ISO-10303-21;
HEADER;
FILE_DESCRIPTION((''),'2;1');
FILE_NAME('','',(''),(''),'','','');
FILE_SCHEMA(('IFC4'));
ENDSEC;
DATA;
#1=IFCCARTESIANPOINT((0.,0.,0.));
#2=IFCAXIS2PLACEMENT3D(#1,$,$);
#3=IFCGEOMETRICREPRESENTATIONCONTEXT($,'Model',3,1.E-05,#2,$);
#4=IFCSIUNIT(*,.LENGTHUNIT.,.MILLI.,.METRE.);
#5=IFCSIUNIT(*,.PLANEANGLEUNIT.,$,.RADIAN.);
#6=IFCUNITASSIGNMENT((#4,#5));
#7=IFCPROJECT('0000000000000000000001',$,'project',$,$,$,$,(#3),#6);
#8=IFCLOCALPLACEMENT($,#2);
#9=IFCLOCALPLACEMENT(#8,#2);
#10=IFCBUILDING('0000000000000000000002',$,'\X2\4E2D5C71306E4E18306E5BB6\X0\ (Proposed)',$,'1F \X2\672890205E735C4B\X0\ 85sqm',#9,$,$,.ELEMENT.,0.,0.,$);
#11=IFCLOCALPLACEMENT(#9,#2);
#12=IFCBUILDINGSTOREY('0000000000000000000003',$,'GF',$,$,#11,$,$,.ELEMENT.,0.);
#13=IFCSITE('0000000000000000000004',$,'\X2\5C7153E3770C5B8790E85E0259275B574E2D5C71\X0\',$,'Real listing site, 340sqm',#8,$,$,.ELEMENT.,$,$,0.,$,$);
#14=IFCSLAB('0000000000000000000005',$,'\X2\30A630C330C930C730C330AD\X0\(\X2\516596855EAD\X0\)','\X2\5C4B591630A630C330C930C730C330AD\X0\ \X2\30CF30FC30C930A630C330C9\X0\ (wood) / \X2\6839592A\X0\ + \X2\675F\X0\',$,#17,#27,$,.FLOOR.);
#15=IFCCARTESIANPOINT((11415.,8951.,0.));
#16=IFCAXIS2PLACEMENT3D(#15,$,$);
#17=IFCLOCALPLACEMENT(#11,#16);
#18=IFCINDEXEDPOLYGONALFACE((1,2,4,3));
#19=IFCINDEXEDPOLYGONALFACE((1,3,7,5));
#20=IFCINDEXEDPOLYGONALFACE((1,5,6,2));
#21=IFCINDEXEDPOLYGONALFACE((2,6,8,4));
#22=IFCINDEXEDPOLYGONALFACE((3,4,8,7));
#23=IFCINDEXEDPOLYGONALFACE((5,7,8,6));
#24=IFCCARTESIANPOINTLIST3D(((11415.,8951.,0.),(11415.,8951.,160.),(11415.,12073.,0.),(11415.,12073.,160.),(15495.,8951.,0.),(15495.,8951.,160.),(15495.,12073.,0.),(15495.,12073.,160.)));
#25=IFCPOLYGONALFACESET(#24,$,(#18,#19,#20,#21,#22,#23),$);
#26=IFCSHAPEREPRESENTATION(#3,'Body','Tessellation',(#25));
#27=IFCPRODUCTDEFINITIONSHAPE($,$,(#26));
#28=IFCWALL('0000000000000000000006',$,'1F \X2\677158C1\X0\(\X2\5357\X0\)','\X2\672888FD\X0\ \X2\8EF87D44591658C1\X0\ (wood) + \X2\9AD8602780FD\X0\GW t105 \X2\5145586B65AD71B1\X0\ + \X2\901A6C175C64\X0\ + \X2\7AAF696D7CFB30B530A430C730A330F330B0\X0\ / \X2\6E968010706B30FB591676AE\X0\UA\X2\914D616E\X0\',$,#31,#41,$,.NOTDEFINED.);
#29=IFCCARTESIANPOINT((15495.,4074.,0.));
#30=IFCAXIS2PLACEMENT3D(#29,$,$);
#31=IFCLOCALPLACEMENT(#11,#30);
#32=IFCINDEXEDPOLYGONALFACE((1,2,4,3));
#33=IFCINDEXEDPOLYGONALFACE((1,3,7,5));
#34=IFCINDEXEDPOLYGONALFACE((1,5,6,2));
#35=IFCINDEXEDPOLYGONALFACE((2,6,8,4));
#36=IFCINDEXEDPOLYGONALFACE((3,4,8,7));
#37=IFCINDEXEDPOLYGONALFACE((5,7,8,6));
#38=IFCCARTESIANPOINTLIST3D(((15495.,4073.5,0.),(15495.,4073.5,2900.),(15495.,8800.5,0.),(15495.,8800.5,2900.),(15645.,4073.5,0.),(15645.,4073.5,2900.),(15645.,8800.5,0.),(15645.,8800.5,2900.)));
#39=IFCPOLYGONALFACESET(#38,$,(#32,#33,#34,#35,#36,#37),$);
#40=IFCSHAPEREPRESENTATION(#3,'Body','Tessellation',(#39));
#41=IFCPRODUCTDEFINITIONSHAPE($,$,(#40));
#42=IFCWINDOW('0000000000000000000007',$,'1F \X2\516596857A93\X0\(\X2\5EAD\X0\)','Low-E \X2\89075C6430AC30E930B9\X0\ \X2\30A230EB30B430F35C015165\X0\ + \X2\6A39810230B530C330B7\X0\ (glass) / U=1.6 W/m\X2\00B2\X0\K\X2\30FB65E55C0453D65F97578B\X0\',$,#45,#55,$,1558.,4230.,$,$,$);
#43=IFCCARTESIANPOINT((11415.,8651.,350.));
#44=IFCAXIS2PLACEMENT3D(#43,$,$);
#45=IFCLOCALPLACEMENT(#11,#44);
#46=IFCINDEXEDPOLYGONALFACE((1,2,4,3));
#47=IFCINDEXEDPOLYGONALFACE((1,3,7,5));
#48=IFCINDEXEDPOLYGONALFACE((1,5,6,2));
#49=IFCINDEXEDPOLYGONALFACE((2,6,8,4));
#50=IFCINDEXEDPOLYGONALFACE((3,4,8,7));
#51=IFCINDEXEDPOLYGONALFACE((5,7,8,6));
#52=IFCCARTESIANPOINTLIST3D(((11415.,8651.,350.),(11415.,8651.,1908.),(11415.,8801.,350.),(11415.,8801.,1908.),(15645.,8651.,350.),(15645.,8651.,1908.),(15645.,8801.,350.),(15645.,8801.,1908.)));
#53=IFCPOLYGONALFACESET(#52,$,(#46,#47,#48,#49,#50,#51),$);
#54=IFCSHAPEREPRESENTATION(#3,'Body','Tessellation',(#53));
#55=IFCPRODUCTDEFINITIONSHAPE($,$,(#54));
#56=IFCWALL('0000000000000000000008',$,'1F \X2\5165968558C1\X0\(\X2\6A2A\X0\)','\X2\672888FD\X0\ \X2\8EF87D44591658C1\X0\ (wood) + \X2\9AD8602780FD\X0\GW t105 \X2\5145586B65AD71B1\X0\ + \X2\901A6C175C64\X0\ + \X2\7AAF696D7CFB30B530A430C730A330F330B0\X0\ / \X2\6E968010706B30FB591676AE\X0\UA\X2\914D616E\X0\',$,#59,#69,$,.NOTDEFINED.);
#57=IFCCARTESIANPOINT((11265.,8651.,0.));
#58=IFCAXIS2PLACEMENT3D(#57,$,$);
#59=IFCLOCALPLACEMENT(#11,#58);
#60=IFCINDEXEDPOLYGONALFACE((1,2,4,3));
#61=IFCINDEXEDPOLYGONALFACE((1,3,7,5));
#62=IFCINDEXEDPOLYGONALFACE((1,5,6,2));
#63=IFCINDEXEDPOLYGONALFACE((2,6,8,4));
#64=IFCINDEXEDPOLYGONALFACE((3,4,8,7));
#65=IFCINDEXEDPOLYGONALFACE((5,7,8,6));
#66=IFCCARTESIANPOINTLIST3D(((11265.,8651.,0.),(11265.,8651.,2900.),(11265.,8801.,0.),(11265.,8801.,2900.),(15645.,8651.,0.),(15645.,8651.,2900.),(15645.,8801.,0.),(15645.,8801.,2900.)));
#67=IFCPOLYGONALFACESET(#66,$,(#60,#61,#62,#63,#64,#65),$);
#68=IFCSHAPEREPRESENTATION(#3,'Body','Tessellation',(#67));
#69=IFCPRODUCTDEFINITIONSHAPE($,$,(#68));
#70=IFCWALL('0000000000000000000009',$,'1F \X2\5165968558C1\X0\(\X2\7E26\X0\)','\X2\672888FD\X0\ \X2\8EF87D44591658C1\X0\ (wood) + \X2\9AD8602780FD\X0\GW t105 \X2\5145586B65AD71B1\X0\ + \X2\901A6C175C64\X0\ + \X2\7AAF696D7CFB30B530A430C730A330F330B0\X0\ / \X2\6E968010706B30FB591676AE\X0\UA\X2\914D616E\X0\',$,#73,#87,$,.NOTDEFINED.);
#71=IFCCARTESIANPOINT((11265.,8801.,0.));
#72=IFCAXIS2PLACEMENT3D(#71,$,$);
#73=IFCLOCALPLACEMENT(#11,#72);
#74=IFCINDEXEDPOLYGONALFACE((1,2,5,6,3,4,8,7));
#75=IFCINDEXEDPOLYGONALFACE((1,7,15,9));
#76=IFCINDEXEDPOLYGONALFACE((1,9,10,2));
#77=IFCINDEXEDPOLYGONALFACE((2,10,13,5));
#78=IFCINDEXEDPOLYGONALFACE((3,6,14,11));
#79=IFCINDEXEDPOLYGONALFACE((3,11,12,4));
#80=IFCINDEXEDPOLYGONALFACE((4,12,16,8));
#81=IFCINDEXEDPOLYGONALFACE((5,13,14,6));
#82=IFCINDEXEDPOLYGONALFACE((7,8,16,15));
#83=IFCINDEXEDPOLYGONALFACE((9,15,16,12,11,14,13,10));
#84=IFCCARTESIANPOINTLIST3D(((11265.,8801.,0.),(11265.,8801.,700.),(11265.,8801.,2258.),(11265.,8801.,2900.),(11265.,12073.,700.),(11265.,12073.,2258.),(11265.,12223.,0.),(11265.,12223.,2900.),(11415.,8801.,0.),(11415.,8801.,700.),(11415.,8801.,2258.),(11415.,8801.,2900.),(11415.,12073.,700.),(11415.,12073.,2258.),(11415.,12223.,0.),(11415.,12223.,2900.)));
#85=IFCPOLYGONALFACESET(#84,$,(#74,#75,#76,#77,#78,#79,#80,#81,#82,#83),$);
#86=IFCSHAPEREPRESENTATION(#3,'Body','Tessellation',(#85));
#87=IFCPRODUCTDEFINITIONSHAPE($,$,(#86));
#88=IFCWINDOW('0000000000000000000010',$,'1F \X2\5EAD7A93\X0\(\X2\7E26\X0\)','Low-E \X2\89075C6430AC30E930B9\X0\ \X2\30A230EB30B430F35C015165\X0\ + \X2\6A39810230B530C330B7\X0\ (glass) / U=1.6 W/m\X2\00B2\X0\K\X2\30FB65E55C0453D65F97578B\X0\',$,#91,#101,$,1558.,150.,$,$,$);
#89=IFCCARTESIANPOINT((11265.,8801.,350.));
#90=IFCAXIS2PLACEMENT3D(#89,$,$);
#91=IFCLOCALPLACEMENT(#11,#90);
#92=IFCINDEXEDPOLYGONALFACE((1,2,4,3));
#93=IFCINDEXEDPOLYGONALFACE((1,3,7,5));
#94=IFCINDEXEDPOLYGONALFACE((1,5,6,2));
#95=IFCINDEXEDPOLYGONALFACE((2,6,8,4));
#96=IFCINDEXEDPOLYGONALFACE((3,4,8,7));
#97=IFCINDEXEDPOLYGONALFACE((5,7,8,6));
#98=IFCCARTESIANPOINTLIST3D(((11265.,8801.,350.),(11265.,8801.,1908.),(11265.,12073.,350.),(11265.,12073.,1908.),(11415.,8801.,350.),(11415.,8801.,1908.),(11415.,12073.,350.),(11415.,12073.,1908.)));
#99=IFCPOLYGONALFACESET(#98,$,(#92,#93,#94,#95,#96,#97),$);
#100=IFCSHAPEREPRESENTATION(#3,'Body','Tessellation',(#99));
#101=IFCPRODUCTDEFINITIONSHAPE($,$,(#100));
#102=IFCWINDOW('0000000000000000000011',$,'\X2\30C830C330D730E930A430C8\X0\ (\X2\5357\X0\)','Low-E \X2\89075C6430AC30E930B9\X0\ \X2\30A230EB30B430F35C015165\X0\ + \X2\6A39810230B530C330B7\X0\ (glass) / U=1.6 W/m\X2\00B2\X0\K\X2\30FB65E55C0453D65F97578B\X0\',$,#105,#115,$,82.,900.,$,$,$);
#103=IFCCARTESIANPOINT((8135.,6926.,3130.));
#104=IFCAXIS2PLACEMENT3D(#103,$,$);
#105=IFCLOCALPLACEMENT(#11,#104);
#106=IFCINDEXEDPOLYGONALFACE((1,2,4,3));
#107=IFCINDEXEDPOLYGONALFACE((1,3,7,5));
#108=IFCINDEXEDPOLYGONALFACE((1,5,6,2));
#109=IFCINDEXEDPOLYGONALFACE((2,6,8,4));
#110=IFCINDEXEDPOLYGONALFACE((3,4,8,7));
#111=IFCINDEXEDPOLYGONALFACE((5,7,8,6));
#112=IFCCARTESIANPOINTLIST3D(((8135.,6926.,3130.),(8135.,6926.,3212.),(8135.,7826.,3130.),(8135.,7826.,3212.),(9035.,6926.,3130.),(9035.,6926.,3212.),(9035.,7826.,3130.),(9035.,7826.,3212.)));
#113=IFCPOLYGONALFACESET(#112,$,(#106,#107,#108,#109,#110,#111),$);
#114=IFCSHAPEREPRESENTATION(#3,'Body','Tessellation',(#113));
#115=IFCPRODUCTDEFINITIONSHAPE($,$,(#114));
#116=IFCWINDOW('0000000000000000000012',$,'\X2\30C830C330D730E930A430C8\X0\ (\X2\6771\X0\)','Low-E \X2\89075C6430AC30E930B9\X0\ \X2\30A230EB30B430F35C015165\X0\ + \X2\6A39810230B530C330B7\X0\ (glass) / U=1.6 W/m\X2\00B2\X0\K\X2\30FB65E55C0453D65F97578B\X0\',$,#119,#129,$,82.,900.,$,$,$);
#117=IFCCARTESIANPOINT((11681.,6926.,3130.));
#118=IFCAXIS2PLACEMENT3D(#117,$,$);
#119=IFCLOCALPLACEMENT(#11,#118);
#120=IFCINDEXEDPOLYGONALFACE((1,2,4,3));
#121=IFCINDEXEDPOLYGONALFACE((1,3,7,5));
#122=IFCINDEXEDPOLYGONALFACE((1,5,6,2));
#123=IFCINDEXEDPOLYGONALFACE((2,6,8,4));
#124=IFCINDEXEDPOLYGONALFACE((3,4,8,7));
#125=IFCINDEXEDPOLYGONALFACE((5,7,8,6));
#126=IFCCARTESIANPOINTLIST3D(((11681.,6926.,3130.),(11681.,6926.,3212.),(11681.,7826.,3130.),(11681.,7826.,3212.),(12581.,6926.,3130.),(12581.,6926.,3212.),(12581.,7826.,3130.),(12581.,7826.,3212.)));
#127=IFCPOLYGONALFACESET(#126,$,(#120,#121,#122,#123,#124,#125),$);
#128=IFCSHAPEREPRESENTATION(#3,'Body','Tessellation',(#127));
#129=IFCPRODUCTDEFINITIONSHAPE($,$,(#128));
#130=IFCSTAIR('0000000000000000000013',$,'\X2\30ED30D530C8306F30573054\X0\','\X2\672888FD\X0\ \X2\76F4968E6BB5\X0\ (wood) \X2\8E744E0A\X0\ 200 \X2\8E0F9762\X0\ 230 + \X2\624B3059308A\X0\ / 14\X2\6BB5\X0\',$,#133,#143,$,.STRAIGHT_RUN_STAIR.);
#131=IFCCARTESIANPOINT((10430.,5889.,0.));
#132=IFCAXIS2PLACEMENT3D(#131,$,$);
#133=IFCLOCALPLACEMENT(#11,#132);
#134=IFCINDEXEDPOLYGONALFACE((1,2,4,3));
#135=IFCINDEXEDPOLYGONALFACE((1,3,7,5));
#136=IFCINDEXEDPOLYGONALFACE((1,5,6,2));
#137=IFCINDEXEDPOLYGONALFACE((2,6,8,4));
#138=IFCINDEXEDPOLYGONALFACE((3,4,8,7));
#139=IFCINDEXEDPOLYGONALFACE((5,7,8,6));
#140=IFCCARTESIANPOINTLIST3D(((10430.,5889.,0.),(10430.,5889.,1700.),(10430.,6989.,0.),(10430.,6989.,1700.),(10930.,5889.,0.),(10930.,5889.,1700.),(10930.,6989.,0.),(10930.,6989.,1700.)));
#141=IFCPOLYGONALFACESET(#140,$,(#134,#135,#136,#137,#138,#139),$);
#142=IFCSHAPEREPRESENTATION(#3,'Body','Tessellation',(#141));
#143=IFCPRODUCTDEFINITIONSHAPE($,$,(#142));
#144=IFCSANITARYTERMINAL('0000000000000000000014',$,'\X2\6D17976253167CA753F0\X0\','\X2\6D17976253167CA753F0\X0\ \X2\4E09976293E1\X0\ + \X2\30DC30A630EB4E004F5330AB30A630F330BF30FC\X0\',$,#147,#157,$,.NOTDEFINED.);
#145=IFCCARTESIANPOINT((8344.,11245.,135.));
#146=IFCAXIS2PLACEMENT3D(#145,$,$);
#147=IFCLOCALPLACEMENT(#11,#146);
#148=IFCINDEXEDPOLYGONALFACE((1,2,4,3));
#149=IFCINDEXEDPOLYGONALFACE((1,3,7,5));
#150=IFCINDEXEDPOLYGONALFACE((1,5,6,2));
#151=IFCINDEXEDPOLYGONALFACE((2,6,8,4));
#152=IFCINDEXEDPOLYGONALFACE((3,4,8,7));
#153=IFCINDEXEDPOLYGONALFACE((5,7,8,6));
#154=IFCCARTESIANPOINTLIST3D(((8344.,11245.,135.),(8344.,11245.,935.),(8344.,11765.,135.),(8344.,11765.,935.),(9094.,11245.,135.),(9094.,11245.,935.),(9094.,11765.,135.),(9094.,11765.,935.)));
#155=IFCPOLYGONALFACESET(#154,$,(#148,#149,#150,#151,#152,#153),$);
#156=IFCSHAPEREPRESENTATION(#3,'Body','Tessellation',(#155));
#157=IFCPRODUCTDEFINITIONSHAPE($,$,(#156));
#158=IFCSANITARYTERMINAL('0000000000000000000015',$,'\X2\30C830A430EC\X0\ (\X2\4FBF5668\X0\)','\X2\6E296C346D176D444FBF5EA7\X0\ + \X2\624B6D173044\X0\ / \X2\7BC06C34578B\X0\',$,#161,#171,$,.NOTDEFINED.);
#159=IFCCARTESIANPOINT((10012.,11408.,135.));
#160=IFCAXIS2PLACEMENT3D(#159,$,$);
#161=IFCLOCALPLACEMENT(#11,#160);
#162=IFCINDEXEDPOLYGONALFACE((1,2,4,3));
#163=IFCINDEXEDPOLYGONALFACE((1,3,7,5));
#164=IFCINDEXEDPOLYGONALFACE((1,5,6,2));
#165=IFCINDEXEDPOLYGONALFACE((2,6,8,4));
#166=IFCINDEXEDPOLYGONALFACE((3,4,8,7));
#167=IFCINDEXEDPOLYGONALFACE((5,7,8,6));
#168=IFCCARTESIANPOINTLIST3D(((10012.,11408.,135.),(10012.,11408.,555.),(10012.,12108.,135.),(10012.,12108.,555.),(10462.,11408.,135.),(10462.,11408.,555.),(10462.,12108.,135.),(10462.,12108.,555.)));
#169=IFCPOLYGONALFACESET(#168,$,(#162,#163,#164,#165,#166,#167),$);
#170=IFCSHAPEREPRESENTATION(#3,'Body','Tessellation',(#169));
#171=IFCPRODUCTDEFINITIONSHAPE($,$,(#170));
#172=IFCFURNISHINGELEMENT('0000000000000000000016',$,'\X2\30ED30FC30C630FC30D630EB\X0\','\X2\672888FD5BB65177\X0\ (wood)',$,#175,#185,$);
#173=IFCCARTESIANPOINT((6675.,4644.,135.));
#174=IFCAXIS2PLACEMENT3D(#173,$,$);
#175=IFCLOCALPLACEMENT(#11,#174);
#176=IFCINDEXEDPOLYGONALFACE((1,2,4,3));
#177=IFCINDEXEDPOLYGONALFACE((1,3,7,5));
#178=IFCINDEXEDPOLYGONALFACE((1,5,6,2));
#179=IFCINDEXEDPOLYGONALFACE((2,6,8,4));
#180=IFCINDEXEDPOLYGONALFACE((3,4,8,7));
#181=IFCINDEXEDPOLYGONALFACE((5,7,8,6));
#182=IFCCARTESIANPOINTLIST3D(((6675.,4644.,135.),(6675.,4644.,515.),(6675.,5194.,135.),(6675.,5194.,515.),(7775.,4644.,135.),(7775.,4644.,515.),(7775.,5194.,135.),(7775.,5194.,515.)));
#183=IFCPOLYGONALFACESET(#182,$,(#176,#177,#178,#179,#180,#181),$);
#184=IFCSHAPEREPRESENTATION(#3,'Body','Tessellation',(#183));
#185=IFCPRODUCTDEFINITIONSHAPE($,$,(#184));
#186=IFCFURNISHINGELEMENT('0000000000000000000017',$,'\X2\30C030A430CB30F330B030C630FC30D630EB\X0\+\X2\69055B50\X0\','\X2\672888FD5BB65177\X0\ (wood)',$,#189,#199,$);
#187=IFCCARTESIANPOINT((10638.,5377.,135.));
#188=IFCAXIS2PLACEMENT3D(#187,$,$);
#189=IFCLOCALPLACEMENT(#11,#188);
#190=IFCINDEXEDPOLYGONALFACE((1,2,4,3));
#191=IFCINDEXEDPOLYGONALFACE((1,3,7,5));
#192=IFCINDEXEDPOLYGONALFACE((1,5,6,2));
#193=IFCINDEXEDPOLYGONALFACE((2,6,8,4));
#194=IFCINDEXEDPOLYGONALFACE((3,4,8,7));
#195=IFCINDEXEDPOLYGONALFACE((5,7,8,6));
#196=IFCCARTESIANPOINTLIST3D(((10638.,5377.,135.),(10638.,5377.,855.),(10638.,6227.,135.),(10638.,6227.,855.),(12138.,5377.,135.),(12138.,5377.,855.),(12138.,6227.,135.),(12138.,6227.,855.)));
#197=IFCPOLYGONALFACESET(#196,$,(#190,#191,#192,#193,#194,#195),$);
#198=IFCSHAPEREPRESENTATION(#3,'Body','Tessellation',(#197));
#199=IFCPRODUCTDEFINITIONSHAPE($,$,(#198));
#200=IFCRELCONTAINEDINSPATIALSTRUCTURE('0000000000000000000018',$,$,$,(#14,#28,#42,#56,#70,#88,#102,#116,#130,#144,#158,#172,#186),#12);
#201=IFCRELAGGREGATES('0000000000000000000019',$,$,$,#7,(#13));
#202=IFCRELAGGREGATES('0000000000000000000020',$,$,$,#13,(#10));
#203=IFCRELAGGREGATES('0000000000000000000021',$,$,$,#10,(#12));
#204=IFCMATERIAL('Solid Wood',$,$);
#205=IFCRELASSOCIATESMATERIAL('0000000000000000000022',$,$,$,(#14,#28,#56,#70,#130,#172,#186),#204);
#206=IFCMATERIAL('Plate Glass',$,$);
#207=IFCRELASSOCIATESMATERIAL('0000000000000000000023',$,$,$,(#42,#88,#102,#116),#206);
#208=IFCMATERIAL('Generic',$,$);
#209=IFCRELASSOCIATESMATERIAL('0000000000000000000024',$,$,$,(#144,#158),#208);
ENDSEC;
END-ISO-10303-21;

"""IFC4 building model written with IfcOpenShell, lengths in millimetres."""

from ifc_helpers import new_model, si_unit, frame, frame_2d, origin, place, context, project, spatial, rectangle, extrude, material, element, fill, save


model = new_model("IFC4")

# Units and contexts
model_context = context("Model", 3, precision=1e-05, world=origin())
ifc_project = project(units=[si_unit("LENGTHUNIT", "METRE", prefix="MILLI"), si_unit("PLANEANGLEUNIT", "RADIAN")], contexts=[model_context])

# Site, building, storey
site_placement = place(None, origin())
site = spatial("IfcSite", under=ifc_project, at=site_placement, Name="山口県宇部市大字中山", ObjectType="Real listing site, 340sqm", CompositionType="ELEMENT", RefElevation=0.0)
building_placement = place(site_placement, origin())
building = spatial("IfcBuilding", under=site, at=building_placement, Name="中山の丘の家 (Proposed)", ObjectType="1F 木造平屋 85sqm", CompositionType="ELEMENT", ElevationOfRefHeight=0.0, ElevationOfTerrain=0.0)
storey_placement = place(building_placement, origin())
storey = spatial("IfcBuildingStorey", under=building, at=storey_placement, Name="GF", CompositionType="ELEMENT", Elevation=0.0)

# Slab
ifc_material_1 = material(Name="Solid Wood")
slab_placement = place(storey_placement, frame((11415.0, 8951.0, 0.0)))
element("IfcSlab", 1, at=slab_placement, inside=storey, material=ifc_material_1, Name="ウッドデッキ(入隅庭)", Description="屋外ウッドデッキ ハードウッド (wood) / 根太 + 束", PredefinedType="FLOOR", context=model_context, shape_type="SweptSolid", body=[
    extrude(rectangle(XDim=4080.0, YDim=3122.0, at=frame_2d((2040.0, 1561.0))), frame((11415.0, 8951.0, 0.0)), (0.0, 0.0, 1.0), 160.0),
])

# Wall, opening, window
wall_1_placement = place(storey_placement, frame((15495.0, 4074.0, 0.0)))
wall_1 = element("IfcWall", 2, at=wall_1_placement, inside=storey, material=ifc_material_1, Name="1F 東壁(南)", Description="木製 軸組外壁 (wood) + 高性能GW t105 充填断熱 + 通気層 + 窯業系サイディング / 準耐火・外皮UA配慮", PredefinedType="NOTDEFINED", context=model_context, shape_type="SweptSolid", body=[
    extrude(rectangle(XDim=150.0, YDim=4727.0, at=frame_2d((75.0, 2363.0))), frame((15495.0, 4074.0, 0.0)), (0.0, 0.0, 1.0), 2900.0),
])
opening_1_placement = place(storey_placement, frame((11415.0, 8651.0, 350.0)))
opening_1 = element("IfcOpeningElement", 3, at=opening_1_placement, cuts=wall_1, PredefinedType="NOTDEFINED", context=model_context, shape_type="SweptSolid", body=[
    extrude(rectangle(XDim=4230.0, YDim=150.0, at=frame_2d((2115.0, 75.0))), frame((11415.0, 8651.0, 350.0)), (0.0, 0.0, 1.0), 1558.0),
])
ifc_material_2 = material(Name="Plate Glass")
window_1_placement = place(storey_placement, frame((11415.0, 8651.0, 350.0)))
window_1 = element("IfcWindow", 4, at=window_1_placement, inside=storey, material=ifc_material_2, Name="1F 入隅窓(庭)", Description="Low-E 複層ガラス アルゴン封入 + 樹脂サッシ (glass) / U=1.6 W/m²K・日射取得型", OverallHeight=1558.0, OverallWidth=4230.0, context=model_context, shape_type="SweptSolid", body=[
    extrude(rectangle(XDim=4230.0, YDim=150.0, at=frame_2d((2115.0, 75.0))), frame((11415.0, 8651.0, 350.0)), (0.0, 0.0, 1.0), 1558.0),
])
fill(opening_1, window_1)

# Wall
wall_2_placement = place(storey_placement, frame((11265.0, 8651.0, 0.0)))
element("IfcWall", 5, at=wall_2_placement, inside=storey, material=ifc_material_1, Name="1F 入隅壁(横)", Description="木製 軸組外壁 (wood) + 高性能GW t105 充填断熱 + 通気層 + 窯業系サイディング / 準耐火・外皮UA配慮", PredefinedType="NOTDEFINED", context=model_context, shape_type="SweptSolid", body=[
    extrude(rectangle(XDim=4380.0, YDim=150.0, at=frame_2d((2190.0, 75.0))), frame((11265.0, 8651.0, 0.0)), (0.0, 0.0, 1.0), 2900.0),
])

# Wall, opening, window
wall_3_placement = place(storey_placement, frame((11265.0, 8801.0, 0.0)))
wall_3 = element("IfcWall", 6, at=wall_3_placement, inside=storey, material=ifc_material_1, Name="1F 入隅壁(縦)", Description="木製 軸組外壁 (wood) + 高性能GW t105 充填断熱 + 通気層 + 窯業系サイディング / 準耐火・外皮UA配慮", PredefinedType="NOTDEFINED", context=model_context, shape_type="SweptSolid", body=[
    extrude(rectangle(XDim=150.0, YDim=3422.0, at=frame_2d((75.0, 1711.0))), frame((11265.0, 8801.0, 0.0)), (0.0, 0.0, 1.0), 2900.0),
])
opening_2_placement = place(storey_placement, frame((11265.0, 8801.0, 350.0)))
opening_2 = element("IfcOpeningElement", 7, at=opening_2_placement, cuts=wall_3, PredefinedType="NOTDEFINED", context=model_context, shape_type="SweptSolid", body=[
    extrude(rectangle(XDim=150.0, YDim=3272.0, at=frame_2d((75.0, 1636.0))), frame((11265.0, 8801.0, 350.0)), (0.0, 0.0, 1.0), 1558.0),
])
window_2_placement = place(storey_placement, frame((11265.0, 8801.0, 350.0)))
window_2 = element("IfcWindow", 8, at=window_2_placement, inside=storey, material=ifc_material_2, Name="1F 庭窓(縦)", Description="Low-E 複層ガラス アルゴン封入 + 樹脂サッシ (glass) / U=1.6 W/m²K・日射取得型", OverallHeight=1558.0, OverallWidth=150.0, context=model_context, shape_type="SweptSolid", body=[
    extrude(rectangle(XDim=150.0, YDim=3272.0, at=frame_2d((75.0, 1636.0))), frame((11265.0, 8801.0, 350.0)), (0.0, 0.0, 1.0), 1558.0),
])
fill(opening_2, window_2)

# Windows
window_3_placement = place(storey_placement, frame((8135.0, 6926.0, 3130.0)))
element("IfcWindow", 9, at=window_3_placement, inside=storey, material=ifc_material_2, Name="トップライト (南)", Description="Low-E 複層ガラス アルゴン封入 + 樹脂サッシ (glass) / U=1.6 W/m²K・日射取得型", OverallHeight=82.0, OverallWidth=900.0, context=model_context, shape_type="SweptSolid", body=[
    extrude(rectangle(XDim=900.0, YDim=900.0, at=frame_2d((450.0, 450.0))), frame((8135.0, 6926.0, 3130.0)), (0.0, 0.0, 1.0), 82.0),
])
window_4_placement = place(storey_placement, frame((11681.0, 6926.0, 3130.0)))
element("IfcWindow", 10, at=window_4_placement, inside=storey, material=ifc_material_2, Name="トップライト (東)", Description="Low-E 複層ガラス アルゴン封入 + 樹脂サッシ (glass) / U=1.6 W/m²K・日射取得型", OverallHeight=82.0, OverallWidth=900.0, context=model_context, shape_type="SweptSolid", body=[
    extrude(rectangle(XDim=900.0, YDim=900.0, at=frame_2d((450.0, 450.0))), frame((11681.0, 6926.0, 3130.0)), (0.0, 0.0, 1.0), 82.0),
])

# Stair
stair_placement = place(storey_placement, frame((10430.0, 5889.0, 0.0)))
element("IfcStair", 11, at=stair_placement, inside=storey, material=ifc_material_1, Name="ロフトはしご", Description="木製 直階段 (wood) 蹴上 200 踏面 230 + 手すり / 14段", PredefinedType="STRAIGHT_RUN_STAIR", context=model_context, shape_type="SweptSolid", body=[
    extrude(rectangle(XDim=500.0, YDim=1100.0, at=frame_2d((250.0, 550.0))), frame((10430.0, 5889.0, 0.0)), (0.0, 0.0, 1.0), 1700.0),
])

# Sanitary terminals
ifc_material_3 = material(Name="Generic")
sanitary_terminal_1_placement = place(storey_placement, frame((8344.0, 11245.0, 135.0)))
element("IfcSanitaryTerminal", 12, at=sanitary_terminal_1_placement, inside=storey, material=ifc_material_3, Name="洗面化粧台", Description="洗面化粧台 三面鏡 + ボウル一体カウンター", PredefinedType="NOTDEFINED", context=model_context, shape_type="SweptSolid", body=[
    extrude(rectangle(XDim=750.0, YDim=520.0, at=frame_2d((375.0, 260.0))), frame((8344.0, 11245.0, 135.0)), (0.0, 0.0, 1.0), 800.0),
])
sanitary_terminal_2_placement = place(storey_placement, frame((10012.0, 11408.0, 135.0)))
element("IfcSanitaryTerminal", 13, at=sanitary_terminal_2_placement, inside=storey, material=ifc_material_3, Name="トイレ (便器)", Description="温水洗浄便座 + 手洗い / 節水型", PredefinedType="NOTDEFINED", context=model_context, shape_type="SweptSolid", body=[
    extrude(rectangle(XDim=450.0, YDim=700.0, at=frame_2d((225.0, 350.0))), frame((10012.0, 11408.0, 135.0)), (0.0, 0.0, 1.0), 420.0),
])

# Furnishing elements
furnishing_1_placement = place(storey_placement, frame((6675.0, 4644.0, 135.0)))
element("IfcFurnishingElement", 14, at=furnishing_1_placement, inside=storey, material=ifc_material_1, Name="ローテーブル", Description="木製家具 (wood)", context=model_context, shape_type="SweptSolid", body=[
    extrude(rectangle(XDim=1100.0, YDim=550.0, at=frame_2d((550.0, 275.0))), frame((6675.0, 4644.0, 135.0)), (0.0, 0.0, 1.0), 380.0),
])
furnishing_2_placement = place(storey_placement, frame((10638.0, 5377.0, 135.0)))
element("IfcFurnishingElement", 15, at=furnishing_2_placement, inside=storey, material=ifc_material_1, Name="ダイニングテーブル+椅子", Description="木製家具 (wood)", context=model_context, shape_type="SweptSolid", body=[
    extrude(rectangle(XDim=1500.0, YDim=850.0, at=frame_2d((750.0, 425.0))), frame((10638.0, 5377.0, 135.0)), (0.0, 0.0, 1.0), 720.0),
])

save(model, "model.ifc")
